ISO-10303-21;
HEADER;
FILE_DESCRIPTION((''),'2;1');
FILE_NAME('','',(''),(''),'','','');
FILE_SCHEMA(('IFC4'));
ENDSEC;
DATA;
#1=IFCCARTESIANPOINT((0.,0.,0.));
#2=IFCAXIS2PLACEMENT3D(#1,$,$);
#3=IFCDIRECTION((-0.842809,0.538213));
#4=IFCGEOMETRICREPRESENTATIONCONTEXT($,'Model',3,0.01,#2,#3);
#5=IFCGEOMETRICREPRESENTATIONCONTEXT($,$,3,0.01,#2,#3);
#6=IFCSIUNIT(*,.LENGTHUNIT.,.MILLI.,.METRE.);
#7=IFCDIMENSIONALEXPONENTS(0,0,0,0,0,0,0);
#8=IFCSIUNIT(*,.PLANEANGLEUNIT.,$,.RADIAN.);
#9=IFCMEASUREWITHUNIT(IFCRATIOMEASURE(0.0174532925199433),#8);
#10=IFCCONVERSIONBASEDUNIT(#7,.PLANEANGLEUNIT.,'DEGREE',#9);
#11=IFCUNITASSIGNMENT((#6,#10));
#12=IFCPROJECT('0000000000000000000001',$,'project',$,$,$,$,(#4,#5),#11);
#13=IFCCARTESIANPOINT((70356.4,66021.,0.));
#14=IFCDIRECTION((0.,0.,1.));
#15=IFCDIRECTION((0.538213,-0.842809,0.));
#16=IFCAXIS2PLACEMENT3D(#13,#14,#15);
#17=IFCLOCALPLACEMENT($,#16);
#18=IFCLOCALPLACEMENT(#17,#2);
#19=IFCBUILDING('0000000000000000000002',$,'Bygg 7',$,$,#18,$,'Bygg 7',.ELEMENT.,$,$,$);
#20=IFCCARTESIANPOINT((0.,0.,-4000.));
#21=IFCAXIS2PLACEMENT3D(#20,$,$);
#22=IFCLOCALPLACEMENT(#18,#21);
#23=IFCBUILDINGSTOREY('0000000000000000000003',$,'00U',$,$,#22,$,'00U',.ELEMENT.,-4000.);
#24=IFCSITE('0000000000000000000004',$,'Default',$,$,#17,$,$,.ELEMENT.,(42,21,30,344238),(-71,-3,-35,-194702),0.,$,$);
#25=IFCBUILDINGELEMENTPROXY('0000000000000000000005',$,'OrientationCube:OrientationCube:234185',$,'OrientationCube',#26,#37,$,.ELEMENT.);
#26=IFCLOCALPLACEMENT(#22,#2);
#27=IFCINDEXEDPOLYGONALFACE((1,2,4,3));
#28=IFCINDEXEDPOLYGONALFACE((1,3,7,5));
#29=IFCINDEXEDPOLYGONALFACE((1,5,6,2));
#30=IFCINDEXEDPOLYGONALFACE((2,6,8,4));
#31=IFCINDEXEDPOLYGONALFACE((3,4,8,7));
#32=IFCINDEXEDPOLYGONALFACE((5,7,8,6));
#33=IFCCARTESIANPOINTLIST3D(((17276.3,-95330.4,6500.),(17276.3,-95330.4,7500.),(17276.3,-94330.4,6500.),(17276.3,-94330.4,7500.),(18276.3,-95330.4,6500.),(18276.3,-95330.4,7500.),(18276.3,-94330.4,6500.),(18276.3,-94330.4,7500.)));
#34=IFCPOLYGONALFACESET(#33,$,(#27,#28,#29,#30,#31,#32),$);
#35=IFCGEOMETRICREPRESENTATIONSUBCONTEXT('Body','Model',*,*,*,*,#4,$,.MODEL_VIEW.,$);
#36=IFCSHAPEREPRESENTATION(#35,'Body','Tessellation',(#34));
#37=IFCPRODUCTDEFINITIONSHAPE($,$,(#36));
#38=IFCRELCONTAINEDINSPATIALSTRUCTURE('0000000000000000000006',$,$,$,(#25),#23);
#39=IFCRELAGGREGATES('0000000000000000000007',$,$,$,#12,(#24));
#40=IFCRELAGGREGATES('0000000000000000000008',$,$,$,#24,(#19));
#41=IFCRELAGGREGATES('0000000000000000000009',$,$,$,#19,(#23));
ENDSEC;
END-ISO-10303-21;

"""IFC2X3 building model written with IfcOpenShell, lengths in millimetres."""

from ifc_helpers import new_model, entity, si_unit, converted_unit, direction, frame, frame_2d, origin, place, context, subcontext, project, spatial, rectangle, extrude, source, transform, mapped, element, save


model = new_model("IFC2X3")

# Units and contexts
model_context = context("Model", 3, precision=0.01, world=origin(), true_north=direction((-0.842809, 0.538213)))
context_of_model = context(None, 3, precision=0.01, world=origin(), true_north=direction((-0.842809, 0.538213)))
body_context = subcontext(model_context, "Body", "Model", "MODEL_VIEW")
ifc_project = project(units=[si_unit("LENGTHUNIT", "METRE", prefix="MILLI"), converted_unit("PLANEANGLEUNIT", "DEGREE", entity("IfcRatioMeasure", 0.0174532925199433), si_unit("PLANEANGLEUNIT", "RADIAN"), dimensions=[0, 0, 0, 0, 0, 0, 0])], contexts=[model_context, context_of_model])

# Site, building, storey
site_placement = place(None, frame((70356.4, 66021.0, 0.0), z_axis=(0.0, 0.0, 1.0), x_axis=(0.538213, -0.842809, 0.0)))
site = spatial("IfcSite", under=ifc_project, at=site_placement, Name="Default", CompositionType="ELEMENT", RefLatitude=(42, 21, 30, 344238), RefLongitude=(-71, -3, -35, -194702), RefElevation=0.0)
building_placement = place(site_placement, origin())
building = spatial("IfcBuilding", under=site, at=building_placement, Name="Bygg 7", LongName="Bygg 7", CompositionType="ELEMENT")
storey_placement = place(building_placement, frame((0.0, 0.0, -4000.0)))
storey = spatial("IfcBuildingStorey", under=building, at=storey_placement, Name="00U", LongName="00U", CompositionType="ELEMENT", Elevation=-4000.0)

# Building element proxy
shared_shape = source(origin(), body_context, "Body", "SweptSolid", [
    extrude(rectangle(XDim=1000.0, YDim=1000.0, at=frame_2d((0.0, 0.0), x_axis=(1.0, 0.0))), frame((0.0, 0.0, 0.0), z_axis=(0.0, 0.0, 1.0), x_axis=(-1.0, 0.0, 0.0)), (0.0, 0.0, 1.0), 1000.0),
])
proxy_placement = place(storey_placement, frame((17776.3, -94830.4, 6500.0)))
element("IfcBuildingElementProxy", 1, at=proxy_placement, inside=storey, Name="OrientationCube:OrientationCube:234185", ObjectType="OrientationCube", CompositionType="ELEMENT", context=body_context, shape_type="MappedRepresentation", body=[
    mapped(shared_shape, transform((0.0, 0.0, 0.0), scale=1.0)),
])

save(model, "model.ifc")
